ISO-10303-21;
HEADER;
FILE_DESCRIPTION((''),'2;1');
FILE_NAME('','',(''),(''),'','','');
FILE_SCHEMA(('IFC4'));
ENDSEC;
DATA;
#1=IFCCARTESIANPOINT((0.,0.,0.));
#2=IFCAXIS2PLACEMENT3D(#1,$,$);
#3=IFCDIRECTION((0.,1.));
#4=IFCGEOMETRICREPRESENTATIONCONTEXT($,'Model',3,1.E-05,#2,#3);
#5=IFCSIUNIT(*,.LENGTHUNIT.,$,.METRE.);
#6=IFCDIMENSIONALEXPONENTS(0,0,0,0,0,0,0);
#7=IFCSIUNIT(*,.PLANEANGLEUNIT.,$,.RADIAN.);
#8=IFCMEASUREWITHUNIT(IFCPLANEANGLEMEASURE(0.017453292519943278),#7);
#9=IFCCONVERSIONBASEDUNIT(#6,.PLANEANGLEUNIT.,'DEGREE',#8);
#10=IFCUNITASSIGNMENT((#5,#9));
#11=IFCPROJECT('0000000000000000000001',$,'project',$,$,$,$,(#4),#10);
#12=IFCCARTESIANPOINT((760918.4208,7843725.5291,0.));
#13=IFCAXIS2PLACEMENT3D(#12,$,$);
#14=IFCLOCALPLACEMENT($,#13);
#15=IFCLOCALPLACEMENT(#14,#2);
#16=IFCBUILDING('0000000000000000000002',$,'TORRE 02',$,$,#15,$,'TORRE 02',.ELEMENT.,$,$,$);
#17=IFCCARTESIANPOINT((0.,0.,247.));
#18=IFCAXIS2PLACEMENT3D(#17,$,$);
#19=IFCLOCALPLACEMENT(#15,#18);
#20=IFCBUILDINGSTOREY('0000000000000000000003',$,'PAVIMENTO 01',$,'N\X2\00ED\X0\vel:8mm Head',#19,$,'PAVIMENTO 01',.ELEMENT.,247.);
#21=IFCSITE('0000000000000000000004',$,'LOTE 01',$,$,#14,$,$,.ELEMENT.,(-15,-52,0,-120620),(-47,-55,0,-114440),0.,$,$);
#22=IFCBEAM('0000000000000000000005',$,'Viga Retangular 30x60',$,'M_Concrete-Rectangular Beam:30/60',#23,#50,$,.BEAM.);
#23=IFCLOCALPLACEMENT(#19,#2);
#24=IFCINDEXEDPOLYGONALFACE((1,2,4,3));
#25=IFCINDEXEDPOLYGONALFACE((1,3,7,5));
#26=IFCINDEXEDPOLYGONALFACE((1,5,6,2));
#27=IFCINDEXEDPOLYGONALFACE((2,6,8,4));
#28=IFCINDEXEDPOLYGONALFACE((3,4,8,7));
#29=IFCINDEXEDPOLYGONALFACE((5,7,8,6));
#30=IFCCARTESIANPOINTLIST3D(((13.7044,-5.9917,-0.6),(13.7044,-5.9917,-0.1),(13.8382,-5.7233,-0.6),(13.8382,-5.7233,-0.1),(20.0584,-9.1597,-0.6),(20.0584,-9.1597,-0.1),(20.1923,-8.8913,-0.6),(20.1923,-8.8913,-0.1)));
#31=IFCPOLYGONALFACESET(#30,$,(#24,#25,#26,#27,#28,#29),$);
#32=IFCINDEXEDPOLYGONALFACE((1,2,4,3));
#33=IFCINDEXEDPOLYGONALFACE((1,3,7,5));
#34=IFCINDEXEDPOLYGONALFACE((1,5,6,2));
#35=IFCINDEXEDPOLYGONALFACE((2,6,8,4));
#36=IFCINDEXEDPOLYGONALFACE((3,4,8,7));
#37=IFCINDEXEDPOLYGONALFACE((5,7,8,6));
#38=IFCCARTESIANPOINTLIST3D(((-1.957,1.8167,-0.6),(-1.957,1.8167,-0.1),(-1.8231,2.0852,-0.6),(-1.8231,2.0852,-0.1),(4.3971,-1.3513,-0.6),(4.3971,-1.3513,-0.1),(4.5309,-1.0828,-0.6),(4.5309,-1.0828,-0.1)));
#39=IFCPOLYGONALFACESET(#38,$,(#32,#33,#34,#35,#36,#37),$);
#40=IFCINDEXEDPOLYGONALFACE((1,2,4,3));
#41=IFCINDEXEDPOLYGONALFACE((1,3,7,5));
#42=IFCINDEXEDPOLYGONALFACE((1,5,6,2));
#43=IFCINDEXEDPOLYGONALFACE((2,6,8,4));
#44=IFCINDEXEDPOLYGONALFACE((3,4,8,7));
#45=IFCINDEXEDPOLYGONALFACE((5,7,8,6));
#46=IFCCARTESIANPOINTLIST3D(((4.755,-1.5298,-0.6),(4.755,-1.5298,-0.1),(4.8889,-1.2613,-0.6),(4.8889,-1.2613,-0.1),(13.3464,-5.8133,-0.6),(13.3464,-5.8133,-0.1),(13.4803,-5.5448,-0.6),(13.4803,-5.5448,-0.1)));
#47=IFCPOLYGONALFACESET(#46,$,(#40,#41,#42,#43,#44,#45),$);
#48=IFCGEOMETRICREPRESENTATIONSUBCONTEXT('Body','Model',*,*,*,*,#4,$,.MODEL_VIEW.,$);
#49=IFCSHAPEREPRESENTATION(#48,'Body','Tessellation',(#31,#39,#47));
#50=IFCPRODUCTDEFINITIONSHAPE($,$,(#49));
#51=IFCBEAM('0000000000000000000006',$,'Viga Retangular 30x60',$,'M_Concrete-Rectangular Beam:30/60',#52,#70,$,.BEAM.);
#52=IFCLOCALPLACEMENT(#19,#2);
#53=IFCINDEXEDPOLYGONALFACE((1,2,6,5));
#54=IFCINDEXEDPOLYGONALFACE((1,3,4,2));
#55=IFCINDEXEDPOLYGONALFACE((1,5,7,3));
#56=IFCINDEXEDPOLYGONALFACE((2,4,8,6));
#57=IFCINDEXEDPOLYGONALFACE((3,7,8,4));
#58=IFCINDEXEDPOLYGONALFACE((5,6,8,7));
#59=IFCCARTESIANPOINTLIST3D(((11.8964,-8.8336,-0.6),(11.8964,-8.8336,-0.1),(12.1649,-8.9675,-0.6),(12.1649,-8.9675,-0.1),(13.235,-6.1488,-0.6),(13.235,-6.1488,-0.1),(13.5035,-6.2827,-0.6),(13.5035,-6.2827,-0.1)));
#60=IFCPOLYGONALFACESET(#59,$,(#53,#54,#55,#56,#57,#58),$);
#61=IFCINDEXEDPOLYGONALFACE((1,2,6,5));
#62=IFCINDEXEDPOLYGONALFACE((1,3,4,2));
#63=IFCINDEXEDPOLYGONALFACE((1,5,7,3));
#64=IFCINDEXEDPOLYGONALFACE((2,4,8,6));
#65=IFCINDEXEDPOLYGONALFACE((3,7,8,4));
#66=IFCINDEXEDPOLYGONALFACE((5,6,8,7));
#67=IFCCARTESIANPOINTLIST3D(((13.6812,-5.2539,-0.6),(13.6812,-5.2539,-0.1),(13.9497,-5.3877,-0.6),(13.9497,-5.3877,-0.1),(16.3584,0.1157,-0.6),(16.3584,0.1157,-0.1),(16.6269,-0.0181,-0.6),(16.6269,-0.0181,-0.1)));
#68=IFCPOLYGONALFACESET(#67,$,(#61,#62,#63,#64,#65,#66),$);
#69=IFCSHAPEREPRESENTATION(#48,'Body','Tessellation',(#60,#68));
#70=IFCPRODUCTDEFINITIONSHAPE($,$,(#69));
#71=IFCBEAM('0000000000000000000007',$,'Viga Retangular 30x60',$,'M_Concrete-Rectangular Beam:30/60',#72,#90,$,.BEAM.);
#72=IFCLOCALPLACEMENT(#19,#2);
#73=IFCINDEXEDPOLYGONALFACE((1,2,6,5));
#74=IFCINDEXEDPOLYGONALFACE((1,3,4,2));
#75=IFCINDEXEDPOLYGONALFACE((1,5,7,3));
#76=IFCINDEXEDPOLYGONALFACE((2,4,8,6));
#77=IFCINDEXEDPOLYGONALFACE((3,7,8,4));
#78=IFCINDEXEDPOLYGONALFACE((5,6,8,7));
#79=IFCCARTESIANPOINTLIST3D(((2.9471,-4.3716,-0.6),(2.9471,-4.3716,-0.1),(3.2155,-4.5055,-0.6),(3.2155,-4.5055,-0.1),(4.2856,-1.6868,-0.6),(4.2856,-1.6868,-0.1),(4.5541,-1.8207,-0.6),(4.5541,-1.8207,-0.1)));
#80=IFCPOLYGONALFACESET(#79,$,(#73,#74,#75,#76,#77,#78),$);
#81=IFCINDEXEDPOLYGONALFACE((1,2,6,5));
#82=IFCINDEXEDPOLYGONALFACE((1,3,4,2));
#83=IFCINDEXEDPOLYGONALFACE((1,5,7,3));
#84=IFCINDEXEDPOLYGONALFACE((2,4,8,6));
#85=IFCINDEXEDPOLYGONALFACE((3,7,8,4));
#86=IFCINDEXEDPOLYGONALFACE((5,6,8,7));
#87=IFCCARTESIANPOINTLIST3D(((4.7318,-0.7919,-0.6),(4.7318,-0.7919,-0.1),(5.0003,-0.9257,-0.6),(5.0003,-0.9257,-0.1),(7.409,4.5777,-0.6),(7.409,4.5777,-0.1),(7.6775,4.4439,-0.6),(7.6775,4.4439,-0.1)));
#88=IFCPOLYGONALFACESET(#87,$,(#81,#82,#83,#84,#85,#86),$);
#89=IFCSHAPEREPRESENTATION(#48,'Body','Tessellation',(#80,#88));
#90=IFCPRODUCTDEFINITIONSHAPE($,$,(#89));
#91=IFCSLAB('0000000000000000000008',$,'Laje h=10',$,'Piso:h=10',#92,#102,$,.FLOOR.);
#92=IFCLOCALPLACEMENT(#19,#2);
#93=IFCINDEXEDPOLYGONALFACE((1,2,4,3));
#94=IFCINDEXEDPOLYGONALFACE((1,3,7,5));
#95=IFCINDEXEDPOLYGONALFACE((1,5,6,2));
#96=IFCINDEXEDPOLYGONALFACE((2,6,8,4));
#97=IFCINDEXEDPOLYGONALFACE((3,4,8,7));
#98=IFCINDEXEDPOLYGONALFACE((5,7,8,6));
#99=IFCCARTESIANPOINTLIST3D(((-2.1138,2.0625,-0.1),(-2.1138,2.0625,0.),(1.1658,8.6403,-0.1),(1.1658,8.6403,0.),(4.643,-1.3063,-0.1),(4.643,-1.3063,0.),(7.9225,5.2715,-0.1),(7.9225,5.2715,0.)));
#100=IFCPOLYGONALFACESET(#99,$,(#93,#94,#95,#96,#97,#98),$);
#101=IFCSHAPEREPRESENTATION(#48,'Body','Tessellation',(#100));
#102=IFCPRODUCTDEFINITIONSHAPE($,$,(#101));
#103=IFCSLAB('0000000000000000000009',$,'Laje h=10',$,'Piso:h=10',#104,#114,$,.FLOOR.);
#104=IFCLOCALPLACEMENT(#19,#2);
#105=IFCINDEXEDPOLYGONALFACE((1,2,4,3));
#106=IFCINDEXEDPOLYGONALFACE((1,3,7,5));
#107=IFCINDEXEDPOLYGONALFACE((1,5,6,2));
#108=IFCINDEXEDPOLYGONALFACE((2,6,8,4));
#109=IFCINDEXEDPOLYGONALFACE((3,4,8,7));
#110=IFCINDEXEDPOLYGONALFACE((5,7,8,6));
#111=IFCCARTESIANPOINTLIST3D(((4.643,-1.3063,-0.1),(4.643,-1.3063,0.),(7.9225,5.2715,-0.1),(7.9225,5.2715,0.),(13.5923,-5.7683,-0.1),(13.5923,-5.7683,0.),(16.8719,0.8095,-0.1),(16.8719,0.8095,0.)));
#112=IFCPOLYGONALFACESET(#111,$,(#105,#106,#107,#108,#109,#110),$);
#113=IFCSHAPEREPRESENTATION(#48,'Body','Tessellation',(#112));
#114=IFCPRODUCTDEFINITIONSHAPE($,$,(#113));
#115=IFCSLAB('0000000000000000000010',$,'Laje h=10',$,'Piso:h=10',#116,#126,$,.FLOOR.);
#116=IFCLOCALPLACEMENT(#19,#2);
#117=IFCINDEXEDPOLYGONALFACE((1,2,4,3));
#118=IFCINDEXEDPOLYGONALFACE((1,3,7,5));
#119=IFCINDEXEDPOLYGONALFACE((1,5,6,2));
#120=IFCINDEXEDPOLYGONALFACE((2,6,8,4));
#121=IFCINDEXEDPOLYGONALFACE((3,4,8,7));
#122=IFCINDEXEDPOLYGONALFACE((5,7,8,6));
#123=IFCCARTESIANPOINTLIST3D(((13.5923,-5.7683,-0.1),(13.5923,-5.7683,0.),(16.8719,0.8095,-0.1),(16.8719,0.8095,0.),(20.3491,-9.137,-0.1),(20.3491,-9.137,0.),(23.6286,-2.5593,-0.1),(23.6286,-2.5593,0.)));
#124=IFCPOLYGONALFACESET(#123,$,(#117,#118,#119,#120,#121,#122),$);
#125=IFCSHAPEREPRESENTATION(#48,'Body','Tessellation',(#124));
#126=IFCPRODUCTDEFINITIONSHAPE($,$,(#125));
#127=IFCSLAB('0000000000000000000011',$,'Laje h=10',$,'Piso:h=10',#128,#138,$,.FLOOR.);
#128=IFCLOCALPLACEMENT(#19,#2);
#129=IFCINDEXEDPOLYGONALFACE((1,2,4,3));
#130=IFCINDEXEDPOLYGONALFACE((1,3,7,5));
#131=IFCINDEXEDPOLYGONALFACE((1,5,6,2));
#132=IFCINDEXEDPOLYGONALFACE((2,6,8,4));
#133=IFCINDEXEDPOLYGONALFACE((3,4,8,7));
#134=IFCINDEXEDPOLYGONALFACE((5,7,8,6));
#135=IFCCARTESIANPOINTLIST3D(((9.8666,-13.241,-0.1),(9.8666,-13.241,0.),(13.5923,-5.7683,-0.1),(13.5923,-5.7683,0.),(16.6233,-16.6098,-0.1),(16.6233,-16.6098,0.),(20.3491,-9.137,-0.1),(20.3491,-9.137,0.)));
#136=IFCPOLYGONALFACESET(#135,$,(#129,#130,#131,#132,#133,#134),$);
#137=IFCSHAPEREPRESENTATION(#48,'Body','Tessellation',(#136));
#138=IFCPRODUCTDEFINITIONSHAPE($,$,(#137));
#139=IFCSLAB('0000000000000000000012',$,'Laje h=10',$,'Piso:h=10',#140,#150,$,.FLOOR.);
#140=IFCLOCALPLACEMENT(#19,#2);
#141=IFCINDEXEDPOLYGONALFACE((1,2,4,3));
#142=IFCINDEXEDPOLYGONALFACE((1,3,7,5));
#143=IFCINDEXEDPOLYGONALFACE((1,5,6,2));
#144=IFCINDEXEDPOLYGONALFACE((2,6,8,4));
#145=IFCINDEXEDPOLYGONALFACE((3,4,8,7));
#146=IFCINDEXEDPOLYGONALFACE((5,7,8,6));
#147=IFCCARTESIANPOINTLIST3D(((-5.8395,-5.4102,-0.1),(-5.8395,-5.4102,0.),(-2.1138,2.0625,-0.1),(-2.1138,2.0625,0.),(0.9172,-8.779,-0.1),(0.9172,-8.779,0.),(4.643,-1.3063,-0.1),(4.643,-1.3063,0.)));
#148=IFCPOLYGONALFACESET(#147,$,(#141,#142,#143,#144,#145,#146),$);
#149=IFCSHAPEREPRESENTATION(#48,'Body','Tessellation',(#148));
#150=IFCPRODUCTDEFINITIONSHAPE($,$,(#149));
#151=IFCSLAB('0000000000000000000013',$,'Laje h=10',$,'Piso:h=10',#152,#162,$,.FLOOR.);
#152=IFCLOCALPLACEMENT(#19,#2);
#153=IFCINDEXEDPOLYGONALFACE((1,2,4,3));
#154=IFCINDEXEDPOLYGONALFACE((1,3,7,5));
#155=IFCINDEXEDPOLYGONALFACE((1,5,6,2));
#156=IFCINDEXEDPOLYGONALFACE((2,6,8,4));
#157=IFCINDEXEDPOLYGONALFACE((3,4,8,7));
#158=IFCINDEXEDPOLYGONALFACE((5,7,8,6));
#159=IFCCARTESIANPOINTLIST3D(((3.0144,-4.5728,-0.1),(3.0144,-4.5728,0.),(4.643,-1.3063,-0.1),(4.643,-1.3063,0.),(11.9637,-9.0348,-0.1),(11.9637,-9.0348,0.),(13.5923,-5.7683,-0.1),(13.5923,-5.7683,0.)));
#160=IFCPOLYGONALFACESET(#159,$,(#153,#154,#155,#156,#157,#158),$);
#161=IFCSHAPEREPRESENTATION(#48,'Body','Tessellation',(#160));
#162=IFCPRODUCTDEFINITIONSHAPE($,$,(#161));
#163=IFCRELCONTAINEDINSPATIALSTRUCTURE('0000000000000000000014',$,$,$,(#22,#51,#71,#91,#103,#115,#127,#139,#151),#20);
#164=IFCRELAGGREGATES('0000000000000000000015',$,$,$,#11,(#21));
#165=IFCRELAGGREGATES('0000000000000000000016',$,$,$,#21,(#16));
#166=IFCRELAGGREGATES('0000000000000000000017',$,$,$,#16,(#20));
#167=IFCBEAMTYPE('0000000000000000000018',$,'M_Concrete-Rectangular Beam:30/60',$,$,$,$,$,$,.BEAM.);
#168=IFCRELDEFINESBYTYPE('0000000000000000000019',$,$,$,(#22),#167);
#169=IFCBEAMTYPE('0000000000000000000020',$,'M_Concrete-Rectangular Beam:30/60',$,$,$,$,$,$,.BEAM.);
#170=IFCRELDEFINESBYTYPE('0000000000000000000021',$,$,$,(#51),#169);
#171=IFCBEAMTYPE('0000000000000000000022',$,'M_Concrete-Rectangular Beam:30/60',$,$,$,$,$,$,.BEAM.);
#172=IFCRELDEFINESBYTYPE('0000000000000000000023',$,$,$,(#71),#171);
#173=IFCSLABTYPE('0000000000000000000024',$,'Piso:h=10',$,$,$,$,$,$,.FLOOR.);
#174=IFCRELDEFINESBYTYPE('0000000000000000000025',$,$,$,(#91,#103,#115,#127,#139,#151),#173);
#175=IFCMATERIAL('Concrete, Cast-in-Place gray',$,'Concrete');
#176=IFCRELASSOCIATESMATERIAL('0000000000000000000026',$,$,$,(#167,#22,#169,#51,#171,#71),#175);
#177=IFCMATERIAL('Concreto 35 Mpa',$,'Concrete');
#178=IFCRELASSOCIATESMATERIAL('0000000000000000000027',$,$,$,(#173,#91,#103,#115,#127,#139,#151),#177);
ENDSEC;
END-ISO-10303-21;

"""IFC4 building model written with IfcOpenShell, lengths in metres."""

from ifc_helpers import new_model, entity, si_unit, converted_unit, direction, frame, origin, place, context, subcontext, project, spatial, indexed_curve, outline, extrude, source, transform, mapped, material, type_object, type_shapes, element, save


model = new_model("IFC4")

# Units and contexts
model_context = context("Model", 3, precision=1e-05, world=origin(), true_north=direction((0.0, 1.0)))
body_context = subcontext(model_context, "Body", "Model", "MODEL_VIEW")
ifc_project = project(units=[si_unit("LENGTHUNIT", "METRE"), converted_unit("PLANEANGLEUNIT", "DEGREE", entity("IfcPlaneAngleMeasure", 0.017453292519943278), si_unit("PLANEANGLEUNIT", "RADIAN"), dimensions=[0, 0, 0, 0, 0, 0, 0])], contexts=[model_context])

# Site, building, storey
site_placement = place(None, frame((760918.4208, 7843725.5291, 0.0)))
site = spatial("IfcSite", under=ifc_project, at=site_placement, Name="LOTE 01", CompositionType="ELEMENT", RefLatitude=(-15, -52, 0, -120620), RefLongitude=(-47, -55, 0, -114440), RefElevation=0.0)
building_placement = place(site_placement, origin())
building = spatial("IfcBuilding", under=site, at=building_placement, Name="TORRE 02", LongName="TORRE 02", CompositionType="ELEMENT")
storey_placement = place(building_placement, frame((0.0, 0.0, 247.0)))
storey = spatial("IfcBuildingStorey", under=building, at=storey_placement, Name="PAVIMENTO 01", ObjectType="Nível:8mm Head", LongName="PAVIMENTO 01", CompositionType="ELEMENT", Elevation=247.0)

# Shared definitions
ifc_material_1 = material(Name="Concrete, Cast-in-Place gray", Category="Concrete")

# Beams
beam_type_1 = type_object("IfcBeamType", Name="M_Concrete-Rectangular Beam:30/60", PredefinedType="BEAM", material=ifc_material_1)
shared_shape_1 = source(origin(), body_context, "Body", "SweptSolid", [
    extrude(outline(indexed_curve([(-0.25, -0.15), (0.25, -0.15), (0.25, 0.15), (-0.25, 0.15), (-0.25, -0.15)], self_intersect=False)), frame((13.7713, -5.8575, 246.65), z_axis=(0.894934, -0.446198, 0.0), x_axis=(0.0, 0.0, -1.0)), (0.0, 0.0, 1.0), 7.1),
    extrude(outline(indexed_curve([(-0.25, -0.15), (0.25, -0.15), (0.25, 0.15), (-0.25, 0.15), (-0.25, -0.15)], self_intersect=False)), frame((-1.89, 1.951, 246.65), z_axis=(0.894934, -0.446198, 0.0), x_axis=(0.0, 0.0, -1.0)), (0.0, 0.0, 1.0), 7.1),
    extrude(outline(indexed_curve([(-0.25, -0.15), (0.25, -0.15), (0.25, 0.15), (-0.25, 0.15), (-0.25, -0.15)], self_intersect=False)), frame((4.822, -1.3955, 246.65), z_axis=(0.894934, -0.446198, 0.0), x_axis=(0.0, 0.0, -1.0)), (0.0, 0.0, 1.0), 9.6),
])
type_shapes(beam_type_1, [shared_shape_1])
beam_1_placement = place(storey_placement, frame((0.0, 0.0, -247.0)))
element("IfcBeam", 1, at=beam_1_placement, inside=storey, type_object=beam_type_1, material=ifc_material_1, Name="Viga Retangular 30x60", ObjectType="M_Concrete-Rectangular Beam:30/60", PredefinedType="BEAM", context=body_context, shape_type="MappedRepresentation", body=[
    mapped(shared_shape_1, transform((0.0, 0.0, 0.0), scale=1.0)),
])
beam_type_2 = type_object("IfcBeamType", Name="M_Concrete-Rectangular Beam:30/60", PredefinedType="BEAM", material=ifc_material_1)
shared_shape_2 = source(origin(), body_context, "Body", "SweptSolid", [
    extrude(outline(indexed_curve([(-0.25, -0.15), (0.25, -0.15), (0.25, 0.15), (-0.25, 0.15), (-0.25, -0.15)], self_intersect=False)), frame((12.0306, -8.9005, 246.65), z_axis=(0.446198, 0.894934, 0.0), x_axis=(0.0, 0.0, 1.0)), (0.0, 0.0, 1.0), 3.0),
    extrude(outline(indexed_curve([(-0.25, -0.15), (0.25, -0.15), (0.25, 0.15), (-0.25, 0.15), (-0.25, -0.15)], self_intersect=False)), frame((13.8154, -5.3208, 246.65), z_axis=(0.446198, 0.894934, 0.0), x_axis=(0.0, 0.0, 1.0)), (0.0, 0.0, 1.0), 6.0),
])
type_shapes(beam_type_2, [shared_shape_2])
beam_2_placement = place(storey_placement, frame((0.0, 0.0, -247.0)))
element("IfcBeam", 2, at=beam_2_placement, inside=storey, type_object=beam_type_2, material=ifc_material_1, Name="Viga Retangular 30x60", ObjectType="M_Concrete-Rectangular Beam:30/60", PredefinedType="BEAM", context=body_context, shape_type="MappedRepresentation", body=[
    mapped(shared_shape_2, transform((0.0, 0.0, 0.0), scale=1.0)),
])
beam_type_3 = type_object("IfcBeamType", Name="M_Concrete-Rectangular Beam:30/60", PredefinedType="BEAM", material=ifc_material_1)
shared_shape_3 = source(origin(), body_context, "Body", "SweptSolid", [
    extrude(outline(indexed_curve([(-0.25, -0.15), (0.25, -0.15), (0.25, 0.15), (-0.25, 0.15), (-0.25, -0.15)], self_intersect=False)), frame((3.0813, -4.4385, 246.65), z_axis=(0.446198, 0.894934, 0.0), x_axis=(0.0, 0.0, 1.0)), (0.0, 0.0, 1.0), 3.0),
    extrude(outline(indexed_curve([(-0.25, -0.15), (0.25, -0.15), (0.25, 0.15), (-0.25, 0.15), (-0.25, -0.15)], self_intersect=False)), frame((4.8661, -0.8588, 246.65), z_axis=(0.446198, 0.894934, 0.0), x_axis=(0.0, 0.0, 1.0)), (0.0, 0.0, 1.0), 6.0),
])
type_shapes(beam_type_3, [shared_shape_3])
beam_3_placement = place(storey_placement, frame((0.0, 0.0, -247.0)))
element("IfcBeam", 3, at=beam_3_placement, inside=storey, type_object=beam_type_3, material=ifc_material_1, Name="Viga Retangular 30x60", ObjectType="M_Concrete-Rectangular Beam:30/60", PredefinedType="BEAM", context=body_context, shape_type="MappedRepresentation", body=[
    mapped(shared_shape_3, transform((0.0, 0.0, 0.0), scale=1.0)),
])

# Slabs
ifc_material_2 = material(Name="Concreto 35 Mpa", Category="Concrete")
slab_type = type_object("IfcSlabType", Name="Piso:h=10", PredefinedType="FLOOR", material=ifc_material_2)
slab_1_placement = place(storey_placement, origin())
element("IfcSlab", 4, at=slab_1_placement, inside=storey, type_object=slab_type, material=ifc_material_2, Name="Laje h=10", ObjectType="Piso:h=10", PredefinedType="FLOOR", context=body_context, shape_type="SweptSolid", body=[
    extrude(outline(indexed_curve([(-3.675, -3.775), (3.675, -3.775), (3.675, 3.775), (-3.675, 3.775), (-3.675, -3.775)], self_intersect=False)), frame((2.9044, 3.667, 0.0), z_axis=(0.0, 0.0, -1.0), x_axis=(-0.446198, -0.894934, 0.0)), (0.0, 0.0, 1.0), 0.1),
])
slab_2_placement = place(storey_placement, origin())
element("IfcSlab", 5, at=slab_2_placement, inside=storey, type_object=slab_type, material=ifc_material_2, Name="Laje h=10", ObjectType="Piso:h=10", PredefinedType="FLOOR", context=body_context, shape_type="SweptSolid", body=[
    extrude(outline(indexed_curve([(-3.675, -5.0), (3.675, -5.0), (3.675, 5.0), (-3.675, 5.0), (-3.675, -5.0)], self_intersect=False)), frame((10.7574, -0.2484, 0.0), z_axis=(0.0, 0.0, -1.0), x_axis=(-0.446198, -0.894934, 0.0)), (0.0, 0.0, 1.0), 0.1),
])
slab_3_placement = place(storey_placement, origin())
element("IfcSlab", 6, at=slab_3_placement, inside=storey, type_object=slab_type, material=ifc_material_2, Name="Laje h=10", ObjectType="Piso:h=10", PredefinedType="FLOOR", context=body_context, shape_type="SweptSolid", body=[
    extrude(outline(indexed_curve([(-3.675, -3.775), (3.675, -3.775), (3.675, 3.775), (-3.675, 3.775), (-3.675, -3.775)], self_intersect=False)), frame((18.6105, -4.1638, 0.0), z_axis=(0.0, 0.0, -1.0), x_axis=(-0.446198, -0.894934, 0.0)), (0.0, 0.0, 1.0), 0.1),
])
slab_4_placement = place(storey_placement, origin())
element("IfcSlab", 7, at=slab_4_placement, inside=storey, type_object=slab_type, material=ifc_material_2, Name="Laje h=10", ObjectType="Piso:h=10", PredefinedType="FLOOR", context=body_context, shape_type="SweptSolid", body=[
    extrude(outline(indexed_curve([(-4.175, -3.775), (4.175, -3.775), (4.175, 3.775), (-4.175, 3.775), (-4.175, -3.775)], self_intersect=False)), frame((15.1078, -11.189, 0.0), z_axis=(0.0, 0.0, -1.0), x_axis=(-0.446198, -0.894934, 0.0)), (0.0, 0.0, 1.0), 0.1),
])
slab_5_placement = place(storey_placement, origin())
element("IfcSlab", 8, at=slab_5_placement, inside=storey, type_object=slab_type, material=ifc_material_2, Name="Laje h=10", ObjectType="Piso:h=10", PredefinedType="FLOOR", context=body_context, shape_type="SweptSolid", body=[
    extrude(outline(indexed_curve([(-4.175, -3.775), (4.175, -3.775), (4.175, 3.775), (-4.175, 3.775), (-4.175, -3.775)], self_intersect=False)), frame((-0.5983, -3.3582, 0.0), z_axis=(0.0, 0.0, -1.0), x_axis=(-0.446198, -0.894934, 0.0)), (0.0, 0.0, 1.0), 0.1),
])
slab_6_placement = place(storey_placement, origin())
element("IfcSlab", 9, at=slab_6_placement, inside=storey, type_object=slab_type, material=ifc_material_2, Name="Laje h=10", ObjectType="Piso:h=10", PredefinedType="FLOOR", context=body_context, shape_type="SweptSolid", body=[
    extrude(outline(indexed_curve([(-1.825, -5.0), (1.825, -5.0), (1.825, 5.0), (-1.825, 5.0), (-1.825, -5.0)], self_intersect=False)), frame((8.3033, -5.1705, 0.0), z_axis=(0.0, 0.0, -1.0), x_axis=(-0.446198, -0.894934, 0.0)), (0.0, 0.0, 1.0), 0.1),
])

save(model, "model.ifc")
